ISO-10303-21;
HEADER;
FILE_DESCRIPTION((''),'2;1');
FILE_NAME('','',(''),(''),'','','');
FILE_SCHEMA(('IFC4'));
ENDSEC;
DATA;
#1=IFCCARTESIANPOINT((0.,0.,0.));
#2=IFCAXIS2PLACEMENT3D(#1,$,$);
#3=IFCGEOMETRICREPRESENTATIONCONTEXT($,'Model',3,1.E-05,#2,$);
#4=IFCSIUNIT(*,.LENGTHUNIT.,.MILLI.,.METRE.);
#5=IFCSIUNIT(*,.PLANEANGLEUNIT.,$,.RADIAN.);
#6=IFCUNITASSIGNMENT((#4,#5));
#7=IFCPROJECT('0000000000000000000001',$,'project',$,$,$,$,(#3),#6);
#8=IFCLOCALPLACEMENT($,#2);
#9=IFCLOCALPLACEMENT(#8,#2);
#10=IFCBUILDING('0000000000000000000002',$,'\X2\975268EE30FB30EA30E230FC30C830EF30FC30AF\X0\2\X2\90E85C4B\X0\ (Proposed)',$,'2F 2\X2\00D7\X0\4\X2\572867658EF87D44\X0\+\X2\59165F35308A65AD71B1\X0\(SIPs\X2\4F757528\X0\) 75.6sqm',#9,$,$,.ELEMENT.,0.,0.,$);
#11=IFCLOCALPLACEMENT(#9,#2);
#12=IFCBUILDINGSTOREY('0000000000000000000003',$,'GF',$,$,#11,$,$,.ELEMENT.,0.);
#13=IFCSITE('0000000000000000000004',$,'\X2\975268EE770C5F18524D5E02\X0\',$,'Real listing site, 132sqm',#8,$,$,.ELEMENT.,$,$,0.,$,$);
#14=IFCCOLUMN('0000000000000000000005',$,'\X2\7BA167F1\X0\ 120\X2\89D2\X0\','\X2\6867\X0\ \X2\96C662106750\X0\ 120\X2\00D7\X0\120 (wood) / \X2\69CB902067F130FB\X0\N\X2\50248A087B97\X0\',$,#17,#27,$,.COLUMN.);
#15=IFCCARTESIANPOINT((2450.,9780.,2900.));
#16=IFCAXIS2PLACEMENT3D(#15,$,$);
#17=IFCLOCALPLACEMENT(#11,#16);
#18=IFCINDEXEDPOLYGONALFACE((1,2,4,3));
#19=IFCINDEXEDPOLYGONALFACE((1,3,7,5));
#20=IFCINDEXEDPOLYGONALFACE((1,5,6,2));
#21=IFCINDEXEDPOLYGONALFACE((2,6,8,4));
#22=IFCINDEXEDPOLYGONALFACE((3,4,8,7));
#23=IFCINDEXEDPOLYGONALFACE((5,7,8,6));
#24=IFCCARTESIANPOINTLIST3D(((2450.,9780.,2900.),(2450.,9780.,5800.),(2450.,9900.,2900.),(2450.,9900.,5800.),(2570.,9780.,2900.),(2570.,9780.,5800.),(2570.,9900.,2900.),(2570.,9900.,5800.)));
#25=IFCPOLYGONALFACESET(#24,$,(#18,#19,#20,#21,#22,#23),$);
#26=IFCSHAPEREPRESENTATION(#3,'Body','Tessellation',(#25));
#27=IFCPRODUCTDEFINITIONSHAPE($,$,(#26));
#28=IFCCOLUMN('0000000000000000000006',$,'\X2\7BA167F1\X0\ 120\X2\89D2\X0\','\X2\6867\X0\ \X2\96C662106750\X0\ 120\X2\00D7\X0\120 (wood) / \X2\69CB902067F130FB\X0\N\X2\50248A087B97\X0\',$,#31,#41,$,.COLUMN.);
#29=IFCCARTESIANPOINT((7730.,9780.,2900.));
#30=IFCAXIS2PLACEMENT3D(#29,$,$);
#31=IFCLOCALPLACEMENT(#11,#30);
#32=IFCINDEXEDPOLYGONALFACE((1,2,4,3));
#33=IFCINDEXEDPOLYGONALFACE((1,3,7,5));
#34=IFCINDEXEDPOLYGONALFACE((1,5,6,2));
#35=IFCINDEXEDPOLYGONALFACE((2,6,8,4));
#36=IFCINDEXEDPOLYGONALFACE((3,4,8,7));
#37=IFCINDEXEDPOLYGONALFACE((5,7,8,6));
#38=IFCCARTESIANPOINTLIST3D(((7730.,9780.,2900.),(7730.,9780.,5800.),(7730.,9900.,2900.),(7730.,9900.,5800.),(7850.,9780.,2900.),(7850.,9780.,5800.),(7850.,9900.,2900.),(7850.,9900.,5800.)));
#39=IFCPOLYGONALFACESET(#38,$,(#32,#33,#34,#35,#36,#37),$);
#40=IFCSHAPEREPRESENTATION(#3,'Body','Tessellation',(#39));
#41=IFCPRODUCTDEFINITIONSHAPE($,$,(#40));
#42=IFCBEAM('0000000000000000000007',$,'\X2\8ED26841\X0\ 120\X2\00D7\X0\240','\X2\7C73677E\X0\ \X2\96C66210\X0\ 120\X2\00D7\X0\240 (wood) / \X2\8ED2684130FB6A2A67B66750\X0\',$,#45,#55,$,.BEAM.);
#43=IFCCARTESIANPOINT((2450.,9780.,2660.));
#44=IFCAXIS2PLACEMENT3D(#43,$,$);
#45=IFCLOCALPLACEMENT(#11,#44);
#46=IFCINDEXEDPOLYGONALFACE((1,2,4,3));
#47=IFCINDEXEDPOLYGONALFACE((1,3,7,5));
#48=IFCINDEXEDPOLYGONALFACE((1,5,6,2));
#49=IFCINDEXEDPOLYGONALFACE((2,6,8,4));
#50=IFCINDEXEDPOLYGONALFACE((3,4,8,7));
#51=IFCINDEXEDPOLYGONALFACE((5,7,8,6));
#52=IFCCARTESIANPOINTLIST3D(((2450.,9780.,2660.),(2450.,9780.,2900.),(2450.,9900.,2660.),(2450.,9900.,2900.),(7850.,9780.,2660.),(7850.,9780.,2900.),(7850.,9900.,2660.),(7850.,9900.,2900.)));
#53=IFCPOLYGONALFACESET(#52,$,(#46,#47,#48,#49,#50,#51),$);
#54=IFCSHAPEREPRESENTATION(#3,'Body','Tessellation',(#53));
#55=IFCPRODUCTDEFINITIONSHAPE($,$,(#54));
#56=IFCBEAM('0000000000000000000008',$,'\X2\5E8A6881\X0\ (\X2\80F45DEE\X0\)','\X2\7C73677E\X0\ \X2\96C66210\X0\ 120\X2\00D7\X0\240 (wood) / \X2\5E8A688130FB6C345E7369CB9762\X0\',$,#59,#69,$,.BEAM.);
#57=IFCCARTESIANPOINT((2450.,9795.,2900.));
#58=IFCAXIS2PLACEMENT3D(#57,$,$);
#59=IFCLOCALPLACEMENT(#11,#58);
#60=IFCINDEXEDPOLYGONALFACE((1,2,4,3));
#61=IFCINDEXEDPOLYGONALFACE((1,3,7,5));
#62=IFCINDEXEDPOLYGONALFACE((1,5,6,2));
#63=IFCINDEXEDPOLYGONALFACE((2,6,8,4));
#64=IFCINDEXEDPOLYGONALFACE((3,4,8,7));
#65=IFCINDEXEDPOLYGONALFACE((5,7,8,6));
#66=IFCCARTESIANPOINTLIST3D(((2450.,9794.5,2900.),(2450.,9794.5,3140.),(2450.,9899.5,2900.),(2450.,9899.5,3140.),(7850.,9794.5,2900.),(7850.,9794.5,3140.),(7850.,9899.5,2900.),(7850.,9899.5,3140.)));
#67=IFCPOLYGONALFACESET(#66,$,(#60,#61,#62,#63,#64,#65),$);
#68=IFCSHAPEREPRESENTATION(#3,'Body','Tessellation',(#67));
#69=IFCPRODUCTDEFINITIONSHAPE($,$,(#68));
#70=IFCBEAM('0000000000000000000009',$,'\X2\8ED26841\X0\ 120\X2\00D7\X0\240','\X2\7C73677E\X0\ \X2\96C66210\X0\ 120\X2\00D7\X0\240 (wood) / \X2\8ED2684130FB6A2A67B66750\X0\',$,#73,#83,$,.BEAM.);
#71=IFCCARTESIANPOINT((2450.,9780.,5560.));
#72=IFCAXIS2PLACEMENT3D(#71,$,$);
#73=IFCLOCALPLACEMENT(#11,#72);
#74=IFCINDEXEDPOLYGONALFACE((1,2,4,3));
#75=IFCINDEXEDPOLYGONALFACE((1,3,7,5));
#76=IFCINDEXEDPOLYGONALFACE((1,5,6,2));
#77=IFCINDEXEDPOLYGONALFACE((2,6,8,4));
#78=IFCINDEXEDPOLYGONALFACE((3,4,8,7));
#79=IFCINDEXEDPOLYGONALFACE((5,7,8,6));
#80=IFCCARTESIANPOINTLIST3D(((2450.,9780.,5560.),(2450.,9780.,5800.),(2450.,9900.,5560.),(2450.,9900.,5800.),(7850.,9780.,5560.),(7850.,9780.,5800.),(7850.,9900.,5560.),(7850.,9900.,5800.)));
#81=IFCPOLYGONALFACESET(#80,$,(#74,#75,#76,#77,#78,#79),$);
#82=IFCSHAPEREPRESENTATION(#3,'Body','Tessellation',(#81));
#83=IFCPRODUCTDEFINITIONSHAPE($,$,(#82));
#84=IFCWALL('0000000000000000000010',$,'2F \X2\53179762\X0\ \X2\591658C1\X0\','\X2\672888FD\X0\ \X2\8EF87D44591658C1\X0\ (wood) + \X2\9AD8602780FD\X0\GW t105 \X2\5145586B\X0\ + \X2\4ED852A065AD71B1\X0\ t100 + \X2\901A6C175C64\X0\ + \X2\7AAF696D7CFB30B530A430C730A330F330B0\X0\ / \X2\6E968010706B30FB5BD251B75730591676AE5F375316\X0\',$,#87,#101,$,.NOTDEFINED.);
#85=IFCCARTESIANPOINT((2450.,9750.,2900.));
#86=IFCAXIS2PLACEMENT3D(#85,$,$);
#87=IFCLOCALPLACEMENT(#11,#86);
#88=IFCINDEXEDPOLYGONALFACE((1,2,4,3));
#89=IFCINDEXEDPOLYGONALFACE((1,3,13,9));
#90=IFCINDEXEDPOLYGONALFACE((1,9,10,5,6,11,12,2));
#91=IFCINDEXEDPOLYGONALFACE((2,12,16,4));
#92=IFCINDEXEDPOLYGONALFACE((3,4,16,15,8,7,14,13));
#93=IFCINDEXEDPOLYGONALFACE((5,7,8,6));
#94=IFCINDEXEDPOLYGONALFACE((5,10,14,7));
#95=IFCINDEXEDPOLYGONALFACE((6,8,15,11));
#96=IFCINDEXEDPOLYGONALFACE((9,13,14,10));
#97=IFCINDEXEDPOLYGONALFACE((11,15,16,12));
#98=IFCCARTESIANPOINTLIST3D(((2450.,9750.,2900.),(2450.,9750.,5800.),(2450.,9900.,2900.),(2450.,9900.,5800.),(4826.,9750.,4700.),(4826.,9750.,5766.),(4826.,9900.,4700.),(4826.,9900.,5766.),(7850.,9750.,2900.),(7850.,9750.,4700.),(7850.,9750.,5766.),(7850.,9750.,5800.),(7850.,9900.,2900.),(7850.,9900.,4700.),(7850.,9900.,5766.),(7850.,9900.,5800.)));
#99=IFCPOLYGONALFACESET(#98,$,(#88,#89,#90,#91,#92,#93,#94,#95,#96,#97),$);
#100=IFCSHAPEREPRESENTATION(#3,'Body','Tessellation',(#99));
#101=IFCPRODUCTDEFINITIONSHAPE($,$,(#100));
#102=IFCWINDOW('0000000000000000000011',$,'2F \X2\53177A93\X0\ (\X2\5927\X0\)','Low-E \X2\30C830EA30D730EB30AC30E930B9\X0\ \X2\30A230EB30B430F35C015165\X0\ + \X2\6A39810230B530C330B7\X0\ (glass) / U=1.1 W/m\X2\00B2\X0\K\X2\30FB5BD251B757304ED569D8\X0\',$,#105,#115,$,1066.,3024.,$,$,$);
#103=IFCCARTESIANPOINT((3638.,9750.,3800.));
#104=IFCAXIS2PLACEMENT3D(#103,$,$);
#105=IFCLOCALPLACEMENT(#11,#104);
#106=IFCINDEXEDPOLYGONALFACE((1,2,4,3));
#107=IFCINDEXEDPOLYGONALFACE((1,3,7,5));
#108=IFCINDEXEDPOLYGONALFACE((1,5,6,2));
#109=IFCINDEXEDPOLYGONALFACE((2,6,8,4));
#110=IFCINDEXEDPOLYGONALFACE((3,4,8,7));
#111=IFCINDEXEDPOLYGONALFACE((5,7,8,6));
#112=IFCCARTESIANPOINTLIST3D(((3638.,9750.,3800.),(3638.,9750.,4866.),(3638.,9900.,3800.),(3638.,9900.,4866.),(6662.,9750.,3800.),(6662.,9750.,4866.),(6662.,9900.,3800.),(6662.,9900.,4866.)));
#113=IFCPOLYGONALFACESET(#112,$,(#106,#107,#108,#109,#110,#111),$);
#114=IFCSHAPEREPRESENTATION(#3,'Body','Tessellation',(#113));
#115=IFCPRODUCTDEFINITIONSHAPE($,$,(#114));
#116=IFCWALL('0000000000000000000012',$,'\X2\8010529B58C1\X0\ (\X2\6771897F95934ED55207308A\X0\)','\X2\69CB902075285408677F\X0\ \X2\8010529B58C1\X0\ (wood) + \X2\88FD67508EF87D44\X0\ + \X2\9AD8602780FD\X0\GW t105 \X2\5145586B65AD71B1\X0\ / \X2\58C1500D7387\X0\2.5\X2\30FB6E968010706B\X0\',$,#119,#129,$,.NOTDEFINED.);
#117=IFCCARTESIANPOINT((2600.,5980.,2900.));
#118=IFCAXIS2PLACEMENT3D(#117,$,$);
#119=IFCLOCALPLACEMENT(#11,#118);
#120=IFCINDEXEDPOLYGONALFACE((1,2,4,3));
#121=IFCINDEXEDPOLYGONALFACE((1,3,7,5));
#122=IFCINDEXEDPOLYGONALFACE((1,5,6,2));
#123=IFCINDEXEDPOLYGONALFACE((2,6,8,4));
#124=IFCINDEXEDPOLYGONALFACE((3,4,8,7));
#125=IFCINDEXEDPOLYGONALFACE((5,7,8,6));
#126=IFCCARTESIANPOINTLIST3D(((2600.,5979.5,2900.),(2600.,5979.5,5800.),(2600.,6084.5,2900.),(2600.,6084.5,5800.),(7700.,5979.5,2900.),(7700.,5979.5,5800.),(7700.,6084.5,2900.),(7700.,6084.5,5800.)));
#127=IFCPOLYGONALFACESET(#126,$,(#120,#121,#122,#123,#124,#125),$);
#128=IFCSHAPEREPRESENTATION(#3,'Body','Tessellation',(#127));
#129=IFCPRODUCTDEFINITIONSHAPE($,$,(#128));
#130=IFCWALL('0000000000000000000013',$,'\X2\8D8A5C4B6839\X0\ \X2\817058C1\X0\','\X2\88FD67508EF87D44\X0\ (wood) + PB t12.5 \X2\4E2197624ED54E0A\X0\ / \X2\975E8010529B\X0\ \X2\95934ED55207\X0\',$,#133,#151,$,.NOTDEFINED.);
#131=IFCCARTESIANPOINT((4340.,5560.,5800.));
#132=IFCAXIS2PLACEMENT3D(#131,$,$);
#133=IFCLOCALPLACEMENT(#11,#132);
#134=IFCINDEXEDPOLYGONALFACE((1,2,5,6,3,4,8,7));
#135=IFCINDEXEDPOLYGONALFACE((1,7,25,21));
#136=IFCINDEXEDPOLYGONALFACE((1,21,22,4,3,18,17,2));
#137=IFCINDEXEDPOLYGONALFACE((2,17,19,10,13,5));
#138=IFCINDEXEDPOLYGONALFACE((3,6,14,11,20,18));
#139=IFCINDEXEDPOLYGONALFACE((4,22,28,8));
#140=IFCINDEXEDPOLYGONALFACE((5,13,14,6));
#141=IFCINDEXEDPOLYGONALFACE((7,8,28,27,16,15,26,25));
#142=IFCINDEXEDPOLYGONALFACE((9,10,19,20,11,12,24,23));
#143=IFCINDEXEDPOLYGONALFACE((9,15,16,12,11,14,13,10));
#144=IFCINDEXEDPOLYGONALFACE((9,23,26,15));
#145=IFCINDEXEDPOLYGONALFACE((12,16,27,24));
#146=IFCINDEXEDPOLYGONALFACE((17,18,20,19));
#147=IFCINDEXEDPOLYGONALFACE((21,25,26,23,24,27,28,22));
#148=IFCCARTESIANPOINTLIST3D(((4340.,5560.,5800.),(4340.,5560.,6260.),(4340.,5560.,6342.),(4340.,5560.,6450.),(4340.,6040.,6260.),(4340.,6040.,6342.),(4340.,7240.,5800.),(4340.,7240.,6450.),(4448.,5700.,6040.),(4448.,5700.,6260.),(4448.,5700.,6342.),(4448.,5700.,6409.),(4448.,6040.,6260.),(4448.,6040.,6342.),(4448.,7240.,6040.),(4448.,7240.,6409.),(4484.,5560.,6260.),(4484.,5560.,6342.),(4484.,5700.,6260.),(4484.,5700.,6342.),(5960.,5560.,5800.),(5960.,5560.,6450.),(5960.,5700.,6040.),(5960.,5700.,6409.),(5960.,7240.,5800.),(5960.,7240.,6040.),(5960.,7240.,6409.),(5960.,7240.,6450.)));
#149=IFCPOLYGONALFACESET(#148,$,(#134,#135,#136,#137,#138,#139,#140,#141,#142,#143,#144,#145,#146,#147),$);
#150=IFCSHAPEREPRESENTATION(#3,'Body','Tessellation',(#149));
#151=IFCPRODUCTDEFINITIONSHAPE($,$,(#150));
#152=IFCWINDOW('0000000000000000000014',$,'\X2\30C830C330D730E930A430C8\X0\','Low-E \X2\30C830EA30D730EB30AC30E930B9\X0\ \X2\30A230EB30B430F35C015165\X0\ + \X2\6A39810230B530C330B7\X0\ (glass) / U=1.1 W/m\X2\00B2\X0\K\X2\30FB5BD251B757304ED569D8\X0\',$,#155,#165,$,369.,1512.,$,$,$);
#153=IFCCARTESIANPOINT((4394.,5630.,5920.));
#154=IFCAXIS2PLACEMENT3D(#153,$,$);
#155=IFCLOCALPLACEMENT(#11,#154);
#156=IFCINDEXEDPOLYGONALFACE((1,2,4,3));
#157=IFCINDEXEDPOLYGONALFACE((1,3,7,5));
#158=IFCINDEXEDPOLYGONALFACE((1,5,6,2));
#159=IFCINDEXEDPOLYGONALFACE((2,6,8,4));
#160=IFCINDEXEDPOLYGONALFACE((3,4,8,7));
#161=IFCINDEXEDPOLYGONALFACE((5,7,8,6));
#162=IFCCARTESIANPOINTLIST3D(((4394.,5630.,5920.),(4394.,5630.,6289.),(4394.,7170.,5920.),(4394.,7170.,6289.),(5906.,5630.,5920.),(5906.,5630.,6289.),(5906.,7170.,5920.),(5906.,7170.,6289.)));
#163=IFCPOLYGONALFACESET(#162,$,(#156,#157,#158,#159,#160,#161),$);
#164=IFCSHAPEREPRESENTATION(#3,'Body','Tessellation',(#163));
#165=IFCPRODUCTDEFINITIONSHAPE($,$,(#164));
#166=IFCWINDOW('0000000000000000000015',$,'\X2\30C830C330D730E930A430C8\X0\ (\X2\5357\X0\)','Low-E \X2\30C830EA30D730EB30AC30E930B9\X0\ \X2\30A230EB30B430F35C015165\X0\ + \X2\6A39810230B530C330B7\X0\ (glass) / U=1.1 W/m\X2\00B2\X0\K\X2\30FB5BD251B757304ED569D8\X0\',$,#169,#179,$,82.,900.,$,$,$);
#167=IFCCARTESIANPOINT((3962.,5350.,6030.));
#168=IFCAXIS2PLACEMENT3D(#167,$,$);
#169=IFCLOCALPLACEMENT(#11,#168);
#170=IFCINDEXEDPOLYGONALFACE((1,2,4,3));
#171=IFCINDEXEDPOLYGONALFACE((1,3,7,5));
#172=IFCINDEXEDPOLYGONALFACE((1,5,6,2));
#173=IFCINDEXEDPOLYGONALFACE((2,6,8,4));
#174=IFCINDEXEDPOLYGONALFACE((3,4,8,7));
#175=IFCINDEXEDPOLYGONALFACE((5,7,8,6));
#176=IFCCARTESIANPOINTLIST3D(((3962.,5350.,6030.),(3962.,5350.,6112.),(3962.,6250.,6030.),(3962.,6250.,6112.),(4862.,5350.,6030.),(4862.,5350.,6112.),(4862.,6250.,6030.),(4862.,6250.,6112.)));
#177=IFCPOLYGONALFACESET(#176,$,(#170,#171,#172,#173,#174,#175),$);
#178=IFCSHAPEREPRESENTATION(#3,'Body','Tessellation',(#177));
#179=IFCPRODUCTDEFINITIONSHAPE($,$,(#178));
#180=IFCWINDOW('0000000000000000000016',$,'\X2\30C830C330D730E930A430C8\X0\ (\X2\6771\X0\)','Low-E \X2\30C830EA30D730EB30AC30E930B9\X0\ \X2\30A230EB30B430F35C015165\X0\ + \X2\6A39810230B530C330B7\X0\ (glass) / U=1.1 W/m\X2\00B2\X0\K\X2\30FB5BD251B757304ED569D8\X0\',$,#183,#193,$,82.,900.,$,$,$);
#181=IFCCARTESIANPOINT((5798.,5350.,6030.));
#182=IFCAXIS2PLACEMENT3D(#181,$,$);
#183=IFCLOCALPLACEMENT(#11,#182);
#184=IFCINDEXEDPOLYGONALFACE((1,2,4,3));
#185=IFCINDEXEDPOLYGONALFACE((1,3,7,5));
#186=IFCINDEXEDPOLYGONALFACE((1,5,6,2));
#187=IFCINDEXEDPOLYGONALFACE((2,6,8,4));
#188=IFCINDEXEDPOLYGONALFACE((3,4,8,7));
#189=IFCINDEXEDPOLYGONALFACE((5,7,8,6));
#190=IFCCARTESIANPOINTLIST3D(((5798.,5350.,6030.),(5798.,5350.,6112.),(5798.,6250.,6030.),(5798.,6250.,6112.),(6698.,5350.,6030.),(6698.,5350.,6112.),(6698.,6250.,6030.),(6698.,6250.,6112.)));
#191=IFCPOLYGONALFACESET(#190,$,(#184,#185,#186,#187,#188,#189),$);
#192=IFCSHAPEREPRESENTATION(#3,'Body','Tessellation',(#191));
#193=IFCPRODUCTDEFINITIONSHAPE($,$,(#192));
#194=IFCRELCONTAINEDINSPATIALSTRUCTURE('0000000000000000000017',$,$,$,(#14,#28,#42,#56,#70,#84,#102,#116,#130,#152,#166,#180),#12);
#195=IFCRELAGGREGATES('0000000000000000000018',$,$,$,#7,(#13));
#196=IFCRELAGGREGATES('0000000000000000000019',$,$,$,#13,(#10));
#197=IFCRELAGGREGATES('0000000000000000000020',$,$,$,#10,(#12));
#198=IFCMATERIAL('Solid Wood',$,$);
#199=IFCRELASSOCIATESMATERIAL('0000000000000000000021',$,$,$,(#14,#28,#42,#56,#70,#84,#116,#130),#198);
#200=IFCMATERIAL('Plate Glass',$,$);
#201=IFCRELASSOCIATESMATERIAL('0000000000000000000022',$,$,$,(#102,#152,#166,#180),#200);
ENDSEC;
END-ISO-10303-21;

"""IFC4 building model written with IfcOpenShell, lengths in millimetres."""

from ifc_helpers import new_model, si_unit, frame, frame_2d, origin, place, context, project, spatial, rectangle, extrude, material, element, fill, save


model = new_model("IFC4")

# Units and contexts
model_context = context("Model", 3, precision=1e-05, world=origin())
ifc_project = project(units=[si_unit("LENGTHUNIT", "METRE", prefix="MILLI"), si_unit("PLANEANGLEUNIT", "RADIAN")], contexts=[model_context])

# Site, building, storey
site_placement = place(None, origin())
site = spatial("IfcSite", under=ifc_project, at=site_placement, Name="青森県弘前市", ObjectType="Real listing site, 132sqm", CompositionType="ELEMENT", RefElevation=0.0)
building_placement = place(site_placement, origin())
building = spatial("IfcBuilding", under=site, at=building_placement, Name="青森・リモートワーク2部屋 (Proposed)", ObjectType="2F 2×4在来軸組+外張り断熱(SIPs併用) 75.6sqm", CompositionType="ELEMENT", ElevationOfRefHeight=0.0, ElevationOfTerrain=0.0)
storey_placement = place(building_placement, origin())
storey = spatial("IfcBuildingStorey", under=building, at=storey_placement, Name="GF", CompositionType="ELEMENT", Elevation=0.0)

# Columns
ifc_material_1 = material(Name="Solid Wood")
column_1_placement = place(storey_placement, frame((2450.0, 9780.0, 2900.0)))
element("IfcColumn", 1, at=column_1_placement, inside=storey, material=ifc_material_1, Name="管柱 120角", Description="桧 集成材 120×120 (wood) / 構造柱・N値計算", PredefinedType="COLUMN", context=model_context, shape_type="SweptSolid", body=[
    extrude(rectangle(XDim=120.0, YDim=120.0, at=frame_2d((60.0, 60.0))), frame((2450.0, 9780.0, 2900.0)), (0.0, 0.0, 1.0), 2900.0),
])
column_2_placement = place(storey_placement, frame((7730.0, 9780.0, 2900.0)))
element("IfcColumn", 2, at=column_2_placement, inside=storey, material=ifc_material_1, Name="管柱 120角", Description="桧 集成材 120×120 (wood) / 構造柱・N値計算", PredefinedType="COLUMN", context=model_context, shape_type="SweptSolid", body=[
    extrude(rectangle(XDim=120.0, YDim=120.0, at=frame_2d((60.0, 60.0))), frame((7730.0, 9780.0, 2900.0)), (0.0, 0.0, 1.0), 2900.0),
])

# Beams
beam_1_placement = place(storey_placement, frame((2450.0, 9780.0, 2660.0)))
element("IfcBeam", 3, at=beam_1_placement, inside=storey, material=ifc_material_1, Name="軒桁 120×240", Description="米松 集成 120×240 (wood) / 軒桁・横架材", PredefinedType="BEAM", context=model_context, shape_type="SweptSolid", body=[
    extrude(rectangle(XDim=5400.0, YDim=120.0, at=frame_2d((2700.0, 60.0))), frame((2450.0, 9780.0, 2660.0)), (0.0, 0.0, 1.0), 240.0),
])
beam_2_placement = place(storey_placement, frame((2450.0, 9795.0, 2900.0)))
element("IfcBeam", 4, at=beam_2_placement, inside=storey, material=ifc_material_1, Name="床梁 (胴差)", Description="米松 集成 120×240 (wood) / 床梁・水平構面", PredefinedType="BEAM", context=model_context, shape_type="SweptSolid", body=[
    extrude(rectangle(XDim=5400.0, YDim=105.0, at=frame_2d((2700.0, 52.0))), frame((2450.0, 9795.0, 2900.0)), (0.0, 0.0, 1.0), 240.0),
])
beam_3_placement = place(storey_placement, frame((2450.0, 9780.0, 5560.0)))
element("IfcBeam", 5, at=beam_3_placement, inside=storey, material=ifc_material_1, Name="軒桁 120×240", Description="米松 集成 120×240 (wood) / 軒桁・横架材", PredefinedType="BEAM", context=model_context, shape_type="SweptSolid", body=[
    extrude(rectangle(XDim=5400.0, YDim=120.0, at=frame_2d((2700.0, 60.0))), frame((2450.0, 9780.0, 5560.0)), (0.0, 0.0, 1.0), 240.0),
])

# Wall, opening, window
wall_1_placement = place(storey_placement, frame((2450.0, 9750.0, 2900.0)))
wall_1 = element("IfcWall", 6, at=wall_1_placement, inside=storey, material=ifc_material_1, Name="2F 北面 外壁", Description="木製 軸組外壁 (wood) + 高性能GW t105 充填 + 付加断熱 t100 + 通気層 + 窯業系サイディング / 準耐火・寒冷地外皮強化", PredefinedType="NOTDEFINED", context=model_context, shape_type="SweptSolid", body=[
    extrude(rectangle(XDim=5400.0, YDim=150.0, at=frame_2d((2700.0, 75.0))), frame((2450.0, 9750.0, 2900.0)), (0.0, 0.0, 1.0), 2900.0),
])
opening_1_placement = place(storey_placement, frame((3638.0, 9750.0, 3800.0)))
opening_1 = element("IfcOpeningElement", 7, at=opening_1_placement, cuts=wall_1, PredefinedType="NOTDEFINED", context=model_context, shape_type="SweptSolid", body=[
    extrude(rectangle(XDim=3024.0, YDim=150.0, at=frame_2d((1512.0, 75.0))), frame((3638.0, 9750.0, 3800.0)), (0.0, 0.0, 1.0), 1066.0),
])
ifc_material_2 = material(Name="Plate Glass")
window_1_placement = place(storey_placement, frame((3638.0, 9750.0, 3800.0)))
window_1 = element("IfcWindow", 8, at=window_1_placement, inside=storey, material=ifc_material_2, Name="2F 北窓 (大)", Description="Low-E トリプルガラス アルゴン封入 + 樹脂サッシ (glass) / U=1.1 W/m²K・寒冷地仕様", OverallHeight=1066.0, OverallWidth=3024.0, context=model_context, shape_type="SweptSolid", body=[
    extrude(rectangle(XDim=3024.0, YDim=150.0, at=frame_2d((1512.0, 75.0))), frame((3638.0, 9750.0, 3800.0)), (0.0, 0.0, 1.0), 1066.0),
])
fill(opening_1, window_1)

# Wall
wall_2_placement = place(storey_placement, frame((2600.0, 5980.0, 2900.0)))
element("IfcWall", 9, at=wall_2_placement, inside=storey, material=ifc_material_1, Name="耐力壁 (東西間仕切り)", Description="構造用合板 耐力壁 (wood) + 製材軸組 + 高性能GW t105 充填断熱 / 壁倍率2.5・準耐火", PredefinedType="NOTDEFINED", context=model_context, shape_type="SweptSolid", body=[
    extrude(rectangle(XDim=5100.0, YDim=105.0, at=frame_2d((2550.0, 52.0))), frame((2600.0, 5980.0, 2900.0)), (0.0, 0.0, 1.0), 2900.0),
])

# Wall, openings, windows
wall_3_placement = place(storey_placement, frame((4340.0, 5560.0, 5800.0)))
wall_3 = element("IfcWall", 10, at=wall_3_placement, inside=storey, material=ifc_material_1, Name="越屋根 腰壁", Description="製材軸組 (wood) + PB t12.5 両面仕上 / 非耐力 間仕切", PredefinedType="NOTDEFINED", context=model_context, shape_type="SweptSolid", body=[
    extrude(rectangle(XDim=1620.0, YDim=1680.0, at=frame_2d((810.0, 840.0))), frame((4340.0, 5560.0, 5800.0)), (0.0, 0.0, 1.0), 650.0),
])
opening_2_placement = place(storey_placement, frame((4394.0, 5630.0, 5920.0)))
opening_2 = element("IfcOpeningElement", 11, at=opening_2_placement, cuts=wall_3, PredefinedType="NOTDEFINED", context=model_context, shape_type="SweptSolid", body=[
    extrude(rectangle(XDim=1512.0, YDim=1540.0, at=frame_2d((756.0, 770.0))), frame((4394.0, 5630.0, 5920.0)), (0.0, 0.0, 1.0), 369.0),
])
opening_3_placement = place(storey_placement, frame((3962.0, 5350.0, 6030.0)))
opening_3 = element("IfcOpeningElement", 12, at=opening_3_placement, cuts=wall_3, PredefinedType="NOTDEFINED", context=model_context, shape_type="SweptSolid", body=[
    extrude(rectangle(XDim=900.0, YDim=900.0, at=frame_2d((450.0, 450.0))), frame((3962.0, 5350.0, 6030.0)), (0.0, 0.0, 1.0), 82.0),
])
opening_4_placement = place(storey_placement, frame((5798.0, 5350.0, 6030.0)))
opening_4 = element("IfcOpeningElement", 13, at=opening_4_placement, cuts=wall_3, PredefinedType="NOTDEFINED", context=model_context, shape_type="SweptSolid", body=[
    extrude(rectangle(XDim=900.0, YDim=900.0, at=frame_2d((450.0, 450.0))), frame((5798.0, 5350.0, 6030.0)), (0.0, 0.0, 1.0), 82.0),
])
window_2_placement = place(storey_placement, frame((4394.0, 5630.0, 5920.0)))
window_2 = element("IfcWindow", 14, at=window_2_placement, inside=storey, material=ifc_material_2, Name="トップライト", Description="Low-E トリプルガラス アルゴン封入 + 樹脂サッシ (glass) / U=1.1 W/m²K・寒冷地仕様", OverallHeight=369.0, OverallWidth=1512.0, context=model_context, shape_type="SweptSolid", body=[
    extrude(rectangle(XDim=1512.0, YDim=1540.0, at=frame_2d((756.0, 770.0))), frame((4394.0, 5630.0, 5920.0)), (0.0, 0.0, 1.0), 369.0),
])
fill(opening_2, window_2)
window_3_placement = place(storey_placement, frame((3962.0, 5350.0, 6030.0)))
window_3 = element("IfcWindow", 15, at=window_3_placement, inside=storey, material=ifc_material_2, Name="トップライト (南)", Description="Low-E トリプルガラス アルゴン封入 + 樹脂サッシ (glass) / U=1.1 W/m²K・寒冷地仕様", OverallHeight=82.0, OverallWidth=900.0, context=model_context, shape_type="SweptSolid", body=[
    extrude(rectangle(XDim=900.0, YDim=900.0, at=frame_2d((450.0, 450.0))), frame((3962.0, 5350.0, 6030.0)), (0.0, 0.0, 1.0), 82.0),
])
fill(opening_3, window_3)
window_4_placement = place(storey_placement, frame((5798.0, 5350.0, 6030.0)))
window_4 = element("IfcWindow", 16, at=window_4_placement, inside=storey, material=ifc_material_2, Name="トップライト (東)", Description="Low-E トリプルガラス アルゴン封入 + 樹脂サッシ (glass) / U=1.1 W/m²K・寒冷地仕様", OverallHeight=82.0, OverallWidth=900.0, context=model_context, shape_type="SweptSolid", body=[
    extrude(rectangle(XDim=900.0, YDim=900.0, at=frame_2d((450.0, 450.0))), frame((5798.0, 5350.0, 6030.0)), (0.0, 0.0, 1.0), 82.0),
])
fill(opening_4, window_4)

save(model, "model.ifc")
